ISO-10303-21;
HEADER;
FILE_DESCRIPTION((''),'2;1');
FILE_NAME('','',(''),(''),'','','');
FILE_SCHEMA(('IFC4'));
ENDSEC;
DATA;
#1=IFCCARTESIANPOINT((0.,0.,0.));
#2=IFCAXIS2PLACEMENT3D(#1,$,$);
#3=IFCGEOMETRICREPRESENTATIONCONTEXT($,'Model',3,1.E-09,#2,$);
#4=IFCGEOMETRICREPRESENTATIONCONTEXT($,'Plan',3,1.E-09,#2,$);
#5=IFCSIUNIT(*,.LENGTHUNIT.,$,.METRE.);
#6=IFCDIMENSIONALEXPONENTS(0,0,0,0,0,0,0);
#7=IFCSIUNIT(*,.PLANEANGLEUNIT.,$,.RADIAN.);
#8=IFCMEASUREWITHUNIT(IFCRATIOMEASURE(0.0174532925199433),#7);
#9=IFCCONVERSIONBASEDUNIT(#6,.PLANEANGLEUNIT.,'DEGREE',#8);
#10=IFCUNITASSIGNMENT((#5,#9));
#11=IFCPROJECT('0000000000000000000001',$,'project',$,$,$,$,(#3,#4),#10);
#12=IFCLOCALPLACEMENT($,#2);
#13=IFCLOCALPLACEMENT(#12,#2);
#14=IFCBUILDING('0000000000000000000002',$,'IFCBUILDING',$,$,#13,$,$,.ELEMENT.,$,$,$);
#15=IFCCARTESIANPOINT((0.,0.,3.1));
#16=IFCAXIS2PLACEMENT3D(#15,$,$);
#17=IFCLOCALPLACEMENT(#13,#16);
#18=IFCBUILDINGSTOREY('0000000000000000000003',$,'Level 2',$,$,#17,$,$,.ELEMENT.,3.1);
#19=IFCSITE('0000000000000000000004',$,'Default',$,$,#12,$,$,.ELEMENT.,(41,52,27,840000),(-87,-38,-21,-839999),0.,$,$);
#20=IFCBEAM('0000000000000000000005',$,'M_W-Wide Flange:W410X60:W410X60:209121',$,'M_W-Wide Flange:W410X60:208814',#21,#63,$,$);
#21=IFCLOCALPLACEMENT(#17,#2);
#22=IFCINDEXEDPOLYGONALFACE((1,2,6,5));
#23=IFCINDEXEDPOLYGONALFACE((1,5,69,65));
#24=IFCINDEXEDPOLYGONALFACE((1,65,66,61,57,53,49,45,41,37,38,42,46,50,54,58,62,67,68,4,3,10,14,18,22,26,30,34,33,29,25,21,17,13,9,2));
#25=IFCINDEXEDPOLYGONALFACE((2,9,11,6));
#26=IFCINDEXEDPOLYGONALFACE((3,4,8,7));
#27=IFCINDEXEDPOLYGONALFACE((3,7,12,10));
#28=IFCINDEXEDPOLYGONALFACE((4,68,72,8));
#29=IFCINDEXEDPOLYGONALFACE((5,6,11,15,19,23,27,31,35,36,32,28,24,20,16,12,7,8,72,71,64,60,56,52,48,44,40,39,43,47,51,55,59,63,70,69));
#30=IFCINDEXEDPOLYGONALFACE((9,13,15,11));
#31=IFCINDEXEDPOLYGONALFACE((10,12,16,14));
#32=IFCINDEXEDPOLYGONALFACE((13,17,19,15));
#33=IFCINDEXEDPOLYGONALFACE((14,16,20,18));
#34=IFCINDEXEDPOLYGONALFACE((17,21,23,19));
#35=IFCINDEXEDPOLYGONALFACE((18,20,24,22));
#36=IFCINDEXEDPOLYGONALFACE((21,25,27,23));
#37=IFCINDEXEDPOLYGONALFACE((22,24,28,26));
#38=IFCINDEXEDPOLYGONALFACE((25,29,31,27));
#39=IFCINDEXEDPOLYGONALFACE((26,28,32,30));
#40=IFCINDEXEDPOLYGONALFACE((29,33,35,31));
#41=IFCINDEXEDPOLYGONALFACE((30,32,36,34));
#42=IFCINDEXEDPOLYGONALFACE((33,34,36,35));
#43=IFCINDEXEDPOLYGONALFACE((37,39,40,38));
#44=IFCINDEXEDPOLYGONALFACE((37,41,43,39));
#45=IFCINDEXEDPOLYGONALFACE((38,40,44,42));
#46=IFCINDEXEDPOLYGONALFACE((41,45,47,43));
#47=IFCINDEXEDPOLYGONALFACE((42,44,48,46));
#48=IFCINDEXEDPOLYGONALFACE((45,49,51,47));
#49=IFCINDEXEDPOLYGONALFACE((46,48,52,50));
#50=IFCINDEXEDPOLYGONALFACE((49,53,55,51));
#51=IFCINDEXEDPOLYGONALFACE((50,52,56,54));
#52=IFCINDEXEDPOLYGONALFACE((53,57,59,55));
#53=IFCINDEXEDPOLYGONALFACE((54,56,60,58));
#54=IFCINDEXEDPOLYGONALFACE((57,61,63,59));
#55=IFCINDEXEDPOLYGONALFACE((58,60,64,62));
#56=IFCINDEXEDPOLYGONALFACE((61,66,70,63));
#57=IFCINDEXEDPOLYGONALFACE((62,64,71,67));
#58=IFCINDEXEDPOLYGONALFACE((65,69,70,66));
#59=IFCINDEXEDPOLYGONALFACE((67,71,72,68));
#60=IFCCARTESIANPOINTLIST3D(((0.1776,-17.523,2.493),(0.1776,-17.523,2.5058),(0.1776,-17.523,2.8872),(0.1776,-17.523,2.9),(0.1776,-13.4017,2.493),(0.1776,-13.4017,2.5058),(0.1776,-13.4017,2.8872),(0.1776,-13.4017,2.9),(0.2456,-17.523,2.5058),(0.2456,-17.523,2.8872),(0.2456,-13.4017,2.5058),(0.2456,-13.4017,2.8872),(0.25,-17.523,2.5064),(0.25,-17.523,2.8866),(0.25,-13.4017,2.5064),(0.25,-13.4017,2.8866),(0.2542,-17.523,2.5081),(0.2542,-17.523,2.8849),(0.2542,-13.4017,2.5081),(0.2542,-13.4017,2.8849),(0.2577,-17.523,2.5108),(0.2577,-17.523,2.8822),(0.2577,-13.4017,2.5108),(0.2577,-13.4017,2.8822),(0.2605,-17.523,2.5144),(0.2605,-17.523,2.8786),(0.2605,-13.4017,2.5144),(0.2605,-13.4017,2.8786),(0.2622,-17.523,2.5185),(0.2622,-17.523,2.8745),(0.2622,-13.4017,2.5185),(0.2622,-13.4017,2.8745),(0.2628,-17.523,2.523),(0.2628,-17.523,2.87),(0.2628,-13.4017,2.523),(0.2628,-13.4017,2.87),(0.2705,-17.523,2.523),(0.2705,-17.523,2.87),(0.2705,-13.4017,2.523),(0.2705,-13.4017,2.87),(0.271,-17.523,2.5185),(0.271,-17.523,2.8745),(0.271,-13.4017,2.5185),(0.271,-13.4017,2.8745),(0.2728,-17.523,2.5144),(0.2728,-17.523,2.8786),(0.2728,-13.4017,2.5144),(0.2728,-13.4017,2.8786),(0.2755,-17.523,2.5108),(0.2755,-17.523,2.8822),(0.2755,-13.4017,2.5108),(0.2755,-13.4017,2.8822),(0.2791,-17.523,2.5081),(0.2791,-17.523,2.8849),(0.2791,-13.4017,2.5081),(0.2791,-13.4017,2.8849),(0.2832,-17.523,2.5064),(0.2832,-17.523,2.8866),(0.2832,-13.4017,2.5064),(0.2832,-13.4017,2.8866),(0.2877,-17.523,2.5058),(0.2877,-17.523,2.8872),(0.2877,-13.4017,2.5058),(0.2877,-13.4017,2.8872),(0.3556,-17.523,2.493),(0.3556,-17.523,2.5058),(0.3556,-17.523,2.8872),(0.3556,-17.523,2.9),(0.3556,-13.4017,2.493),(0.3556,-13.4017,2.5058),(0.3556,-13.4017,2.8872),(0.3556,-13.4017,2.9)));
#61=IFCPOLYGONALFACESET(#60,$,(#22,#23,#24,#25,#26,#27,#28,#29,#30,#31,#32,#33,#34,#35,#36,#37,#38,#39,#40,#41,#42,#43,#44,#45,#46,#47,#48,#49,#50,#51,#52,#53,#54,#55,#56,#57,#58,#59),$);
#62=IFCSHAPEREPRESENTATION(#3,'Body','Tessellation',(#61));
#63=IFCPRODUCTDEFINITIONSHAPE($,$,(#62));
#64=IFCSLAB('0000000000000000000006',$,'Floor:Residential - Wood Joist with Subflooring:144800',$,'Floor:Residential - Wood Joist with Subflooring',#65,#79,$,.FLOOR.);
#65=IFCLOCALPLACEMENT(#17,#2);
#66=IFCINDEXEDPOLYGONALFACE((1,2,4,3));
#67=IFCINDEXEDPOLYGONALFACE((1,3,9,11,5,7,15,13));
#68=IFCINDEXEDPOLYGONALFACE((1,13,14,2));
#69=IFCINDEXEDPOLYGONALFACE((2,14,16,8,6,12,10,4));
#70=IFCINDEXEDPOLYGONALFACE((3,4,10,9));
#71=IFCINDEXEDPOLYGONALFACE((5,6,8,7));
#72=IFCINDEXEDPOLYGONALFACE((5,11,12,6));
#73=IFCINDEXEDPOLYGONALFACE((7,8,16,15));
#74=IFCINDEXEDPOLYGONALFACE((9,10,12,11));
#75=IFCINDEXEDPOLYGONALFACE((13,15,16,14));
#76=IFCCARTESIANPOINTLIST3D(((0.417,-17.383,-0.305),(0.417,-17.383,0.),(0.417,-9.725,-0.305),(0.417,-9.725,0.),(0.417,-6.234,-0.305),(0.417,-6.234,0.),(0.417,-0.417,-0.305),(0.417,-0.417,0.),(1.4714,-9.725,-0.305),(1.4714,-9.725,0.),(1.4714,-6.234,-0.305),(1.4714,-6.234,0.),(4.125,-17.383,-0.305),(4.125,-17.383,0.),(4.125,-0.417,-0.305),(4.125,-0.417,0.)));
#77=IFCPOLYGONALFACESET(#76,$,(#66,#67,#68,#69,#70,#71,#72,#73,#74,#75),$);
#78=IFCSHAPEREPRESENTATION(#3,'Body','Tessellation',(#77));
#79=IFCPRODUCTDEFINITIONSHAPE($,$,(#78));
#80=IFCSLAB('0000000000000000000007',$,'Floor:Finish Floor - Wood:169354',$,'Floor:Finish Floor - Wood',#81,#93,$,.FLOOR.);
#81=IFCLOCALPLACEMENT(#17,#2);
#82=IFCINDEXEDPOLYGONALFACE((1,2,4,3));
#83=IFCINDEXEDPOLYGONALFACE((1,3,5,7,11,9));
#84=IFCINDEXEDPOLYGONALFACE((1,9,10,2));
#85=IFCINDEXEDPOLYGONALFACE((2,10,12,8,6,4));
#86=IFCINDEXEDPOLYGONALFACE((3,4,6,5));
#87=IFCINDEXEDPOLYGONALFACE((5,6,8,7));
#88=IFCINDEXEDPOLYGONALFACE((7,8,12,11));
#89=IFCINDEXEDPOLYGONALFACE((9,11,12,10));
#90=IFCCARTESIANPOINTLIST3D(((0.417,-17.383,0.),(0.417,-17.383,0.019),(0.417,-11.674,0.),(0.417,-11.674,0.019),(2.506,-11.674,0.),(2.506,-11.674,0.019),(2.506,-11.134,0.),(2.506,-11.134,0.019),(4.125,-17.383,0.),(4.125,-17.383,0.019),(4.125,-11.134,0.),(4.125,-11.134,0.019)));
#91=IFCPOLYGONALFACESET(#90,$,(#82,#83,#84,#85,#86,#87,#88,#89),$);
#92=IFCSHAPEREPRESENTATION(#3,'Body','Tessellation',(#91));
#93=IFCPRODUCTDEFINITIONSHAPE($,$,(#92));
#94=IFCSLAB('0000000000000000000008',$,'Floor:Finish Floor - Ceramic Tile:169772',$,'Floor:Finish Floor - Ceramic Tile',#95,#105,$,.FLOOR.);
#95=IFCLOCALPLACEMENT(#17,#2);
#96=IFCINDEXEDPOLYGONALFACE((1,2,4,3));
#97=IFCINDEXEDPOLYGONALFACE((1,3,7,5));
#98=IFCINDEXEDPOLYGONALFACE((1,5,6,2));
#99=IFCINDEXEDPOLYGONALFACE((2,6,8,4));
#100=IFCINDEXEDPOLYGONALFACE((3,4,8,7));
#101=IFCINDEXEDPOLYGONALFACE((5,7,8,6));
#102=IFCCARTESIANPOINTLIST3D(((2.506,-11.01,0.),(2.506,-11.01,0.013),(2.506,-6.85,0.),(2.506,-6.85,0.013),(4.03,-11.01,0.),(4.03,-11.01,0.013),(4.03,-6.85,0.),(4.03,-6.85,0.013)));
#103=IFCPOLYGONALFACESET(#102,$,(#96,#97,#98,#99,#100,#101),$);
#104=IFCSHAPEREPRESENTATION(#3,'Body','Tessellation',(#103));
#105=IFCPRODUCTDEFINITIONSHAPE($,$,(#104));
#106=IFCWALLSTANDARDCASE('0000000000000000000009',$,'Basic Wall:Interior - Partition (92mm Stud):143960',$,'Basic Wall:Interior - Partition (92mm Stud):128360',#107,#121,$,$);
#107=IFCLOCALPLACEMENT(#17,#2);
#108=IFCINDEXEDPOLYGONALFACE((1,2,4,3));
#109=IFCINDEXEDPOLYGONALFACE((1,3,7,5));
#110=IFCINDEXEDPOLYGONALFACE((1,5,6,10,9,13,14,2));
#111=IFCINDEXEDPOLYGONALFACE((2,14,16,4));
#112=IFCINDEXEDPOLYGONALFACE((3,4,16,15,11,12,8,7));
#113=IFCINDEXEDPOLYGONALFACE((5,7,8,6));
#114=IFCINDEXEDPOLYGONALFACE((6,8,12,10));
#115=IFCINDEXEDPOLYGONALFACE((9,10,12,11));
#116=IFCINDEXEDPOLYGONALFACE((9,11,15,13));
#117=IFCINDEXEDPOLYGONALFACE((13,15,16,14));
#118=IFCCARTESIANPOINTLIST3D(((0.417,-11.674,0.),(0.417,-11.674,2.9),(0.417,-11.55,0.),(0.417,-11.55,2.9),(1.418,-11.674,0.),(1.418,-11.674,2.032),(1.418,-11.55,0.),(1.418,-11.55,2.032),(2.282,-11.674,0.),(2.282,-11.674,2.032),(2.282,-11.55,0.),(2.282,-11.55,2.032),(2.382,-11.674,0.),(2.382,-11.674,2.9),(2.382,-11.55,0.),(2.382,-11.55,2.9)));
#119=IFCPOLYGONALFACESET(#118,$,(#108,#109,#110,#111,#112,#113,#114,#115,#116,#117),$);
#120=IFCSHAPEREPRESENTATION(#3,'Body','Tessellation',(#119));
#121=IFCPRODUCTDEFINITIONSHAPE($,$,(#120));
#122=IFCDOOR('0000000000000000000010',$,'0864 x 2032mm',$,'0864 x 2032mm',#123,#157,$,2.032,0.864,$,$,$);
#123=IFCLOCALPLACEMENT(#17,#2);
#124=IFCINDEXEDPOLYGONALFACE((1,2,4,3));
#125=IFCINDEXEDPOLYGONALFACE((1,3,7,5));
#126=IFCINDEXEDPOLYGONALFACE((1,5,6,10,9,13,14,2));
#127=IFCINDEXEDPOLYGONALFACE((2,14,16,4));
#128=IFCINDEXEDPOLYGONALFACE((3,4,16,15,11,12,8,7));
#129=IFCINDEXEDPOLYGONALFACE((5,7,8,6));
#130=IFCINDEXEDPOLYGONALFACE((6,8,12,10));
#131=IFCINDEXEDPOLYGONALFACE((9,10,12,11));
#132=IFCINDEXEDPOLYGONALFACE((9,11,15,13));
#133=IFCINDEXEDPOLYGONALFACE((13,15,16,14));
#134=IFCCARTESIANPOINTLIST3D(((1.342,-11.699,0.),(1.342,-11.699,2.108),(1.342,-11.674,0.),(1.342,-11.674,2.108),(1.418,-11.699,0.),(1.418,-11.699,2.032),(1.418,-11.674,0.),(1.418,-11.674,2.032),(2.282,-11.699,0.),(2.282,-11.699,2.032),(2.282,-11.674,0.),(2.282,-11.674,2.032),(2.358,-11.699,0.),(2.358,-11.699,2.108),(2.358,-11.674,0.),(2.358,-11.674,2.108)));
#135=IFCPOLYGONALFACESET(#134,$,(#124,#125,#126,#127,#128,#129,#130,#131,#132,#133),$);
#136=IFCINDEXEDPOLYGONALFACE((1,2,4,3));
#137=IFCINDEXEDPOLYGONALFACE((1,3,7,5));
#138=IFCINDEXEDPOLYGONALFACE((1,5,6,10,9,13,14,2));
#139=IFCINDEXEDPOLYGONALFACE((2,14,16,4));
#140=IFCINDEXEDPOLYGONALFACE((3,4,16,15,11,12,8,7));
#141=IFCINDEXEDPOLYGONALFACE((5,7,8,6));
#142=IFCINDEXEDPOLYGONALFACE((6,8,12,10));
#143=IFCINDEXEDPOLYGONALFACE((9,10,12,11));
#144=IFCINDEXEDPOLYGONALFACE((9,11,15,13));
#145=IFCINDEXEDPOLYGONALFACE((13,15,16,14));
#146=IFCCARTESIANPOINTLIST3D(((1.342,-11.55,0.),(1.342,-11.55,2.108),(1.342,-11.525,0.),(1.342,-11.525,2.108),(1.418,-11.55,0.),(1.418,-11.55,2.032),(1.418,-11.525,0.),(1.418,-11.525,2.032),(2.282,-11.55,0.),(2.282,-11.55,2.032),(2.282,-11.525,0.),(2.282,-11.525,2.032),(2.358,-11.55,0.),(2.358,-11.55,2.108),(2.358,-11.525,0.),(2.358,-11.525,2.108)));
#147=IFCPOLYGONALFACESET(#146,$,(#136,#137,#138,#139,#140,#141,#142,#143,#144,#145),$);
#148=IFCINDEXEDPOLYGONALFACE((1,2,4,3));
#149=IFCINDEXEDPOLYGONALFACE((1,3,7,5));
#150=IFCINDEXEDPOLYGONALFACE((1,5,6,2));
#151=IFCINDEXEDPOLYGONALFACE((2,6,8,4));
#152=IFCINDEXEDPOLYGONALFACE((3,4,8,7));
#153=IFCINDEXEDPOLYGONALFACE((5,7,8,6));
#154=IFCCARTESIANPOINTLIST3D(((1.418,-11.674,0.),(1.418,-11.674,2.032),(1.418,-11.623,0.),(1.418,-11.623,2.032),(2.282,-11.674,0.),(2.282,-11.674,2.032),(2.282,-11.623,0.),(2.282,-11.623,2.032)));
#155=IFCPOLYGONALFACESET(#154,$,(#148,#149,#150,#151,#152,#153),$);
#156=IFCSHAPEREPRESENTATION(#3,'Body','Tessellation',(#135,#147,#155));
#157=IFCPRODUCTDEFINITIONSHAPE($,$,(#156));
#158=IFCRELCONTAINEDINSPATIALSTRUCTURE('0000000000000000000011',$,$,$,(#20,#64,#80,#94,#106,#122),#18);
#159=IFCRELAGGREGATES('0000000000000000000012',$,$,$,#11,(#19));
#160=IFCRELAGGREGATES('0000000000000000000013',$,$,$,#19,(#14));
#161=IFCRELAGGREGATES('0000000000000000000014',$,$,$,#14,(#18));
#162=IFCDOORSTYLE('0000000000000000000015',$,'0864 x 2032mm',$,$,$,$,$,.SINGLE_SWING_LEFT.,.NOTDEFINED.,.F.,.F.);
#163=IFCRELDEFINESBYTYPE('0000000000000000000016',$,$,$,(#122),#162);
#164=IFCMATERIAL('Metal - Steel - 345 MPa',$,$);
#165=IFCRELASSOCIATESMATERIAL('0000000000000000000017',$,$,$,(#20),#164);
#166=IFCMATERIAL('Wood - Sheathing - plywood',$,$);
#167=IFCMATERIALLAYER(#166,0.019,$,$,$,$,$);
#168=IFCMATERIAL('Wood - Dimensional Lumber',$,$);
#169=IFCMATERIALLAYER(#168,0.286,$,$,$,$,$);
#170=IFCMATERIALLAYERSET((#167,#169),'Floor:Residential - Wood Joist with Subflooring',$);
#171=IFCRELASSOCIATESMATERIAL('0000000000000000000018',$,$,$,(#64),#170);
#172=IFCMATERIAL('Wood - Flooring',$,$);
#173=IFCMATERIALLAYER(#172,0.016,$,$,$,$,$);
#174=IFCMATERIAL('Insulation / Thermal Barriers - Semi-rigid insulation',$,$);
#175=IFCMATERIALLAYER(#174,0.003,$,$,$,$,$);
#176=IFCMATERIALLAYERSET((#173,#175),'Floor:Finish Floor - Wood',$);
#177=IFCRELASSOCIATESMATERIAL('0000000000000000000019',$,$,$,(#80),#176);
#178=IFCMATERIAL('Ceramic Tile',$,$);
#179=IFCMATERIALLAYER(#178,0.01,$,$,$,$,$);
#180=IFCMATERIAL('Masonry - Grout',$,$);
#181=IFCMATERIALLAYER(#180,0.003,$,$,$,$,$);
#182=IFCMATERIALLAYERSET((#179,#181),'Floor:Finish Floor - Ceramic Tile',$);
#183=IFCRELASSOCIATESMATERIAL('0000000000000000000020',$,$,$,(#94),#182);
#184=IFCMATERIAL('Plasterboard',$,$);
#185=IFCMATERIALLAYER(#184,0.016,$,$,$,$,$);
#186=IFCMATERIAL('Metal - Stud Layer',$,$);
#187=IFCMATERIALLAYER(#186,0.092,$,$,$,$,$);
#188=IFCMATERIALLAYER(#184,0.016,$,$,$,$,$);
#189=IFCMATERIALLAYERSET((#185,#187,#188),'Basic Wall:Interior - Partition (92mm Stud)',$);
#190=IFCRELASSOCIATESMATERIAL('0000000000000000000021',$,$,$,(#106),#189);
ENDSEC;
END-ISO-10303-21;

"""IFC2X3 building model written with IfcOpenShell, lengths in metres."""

from ifc_helpers import new_model, entity, si_unit, converted_unit, frame, frame_2d, origin, origin_2d_with_axis, place, context, project, spatial, polyline, circle_curve, parameter, trimmed, segment, composite_curve, rectangle, outline, extrude, source, transform, mapped, material, layer, layer_set, layer_usage, type_object, type_shapes, element, fill, save


model = new_model("IFC2X3")

# Units and contexts
model_context = context("Model", 3, precision=1e-09, world=origin())
plan_context = context("Plan", 3, precision=1e-09, world=origin())
ifc_project = project(units=[si_unit("LENGTHUNIT", "METRE"), converted_unit("PLANEANGLEUNIT", "DEGREE", entity("IfcRatioMeasure", 0.0174532925199433), si_unit("PLANEANGLEUNIT", "RADIAN"), dimensions=[0, 0, 0, 0, 0, 0, 0])], contexts=[model_context, plan_context])

# Site, building, storey
site_placement = place(None, origin())
site = spatial("IfcSite", under=ifc_project, at=site_placement, Name="Default", CompositionType="ELEMENT", RefLatitude=(41, 52, 27, 840000), RefLongitude=(-87, -38, -21, -839999), RefElevation=0.0)
building_placement = place(site_placement, origin())
building = spatial("IfcBuilding", under=site, at=building_placement, Name="IFCBUILDING", CompositionType="ELEMENT")
storey_placement = place(building_placement, frame((0.0, 0.0, 3.1)))
storey = spatial("IfcBuildingStorey", under=building, at=storey_placement, Name="Level 2", CompositionType="ELEMENT", Elevation=3.1)

# Beam
ifc_material_1 = material(Name="Metal - Steel - 345 MPa")
beam_placement = place(storey_placement, frame((0.2666, -13.4017, 2.9), z_axis=(0.0, 0.0, 1.0), x_axis=(-1.0, 0.0, 0.0)))
element("IfcBeam", 1, at=beam_placement, inside=storey, material=ifc_material_1, Name="M_W-Wide Flange:W410X60:W410X60:209121", ObjectType="M_W-Wide Flange:W410X60:208814", context=model_context, shape_type="SweptSolid", body=[
    extrude(outline(composite_curve([segment(polyline([(0.1907, -0.089), (0.2035, -0.089)]), True, "CONTINUOUS"), segment(polyline([(0.2035, -0.089), (0.2035, 0.089)]), True, "CONTINUOUS"), segment(polyline([(0.2035, 0.089), (0.1907, 0.089)]), True, "CONTINUOUS"), segment(polyline([(0.1907, 0.089), (0.1907, 0.021)]), True, "CONTINUOUS"), segment(trimmed(circle_curve(frame_2d((0.1735, 0.021), x_axis=(1.0, 0.0)), 0.0172), [parameter(270.0)], [parameter(360.0)], True, "PARAMETER"), False, "CONTINUOUS"), segment(polyline([(0.1735, 0.0038), (-0.1735, 0.0038)]), True, "CONTINUOUS"), segment(trimmed(circle_curve(frame_2d((-0.1735, 0.021), x_axis=(0.0, -1.0)), 0.0172), [parameter(270.0)], [parameter(360.0)], True, "PARAMETER"), False, "CONTINUOUS"), segment(polyline([(-0.1907, 0.021), (-0.1907, 0.089)]), True, "CONTINUOUS"), segment(polyline([(-0.1907, 0.089), (-0.2035, 0.089)]), True, "CONTINUOUS"), segment(polyline([(-0.2035, 0.089), (-0.2035, -0.089)]), True, "CONTINUOUS"), segment(polyline([(-0.2035, -0.089), (-0.1907, -0.089)]), True, "CONTINUOUS"), segment(polyline([(-0.1907, -0.089), (-0.1907, -0.0211)]), True, "CONTINUOUS"), segment(trimmed(circle_curve(frame_2d((-0.1735, -0.0211), x_axis=(-1.0, 0.0)), 0.0172), [parameter(270.0)], [parameter(0.0)], True, "PARAMETER"), False, "CONTINUOUS"), segment(polyline([(-0.1735, -0.0039), (0.1735, -0.0039)]), True, "CONTINUOUS"), segment(trimmed(circle_curve(frame_2d((0.1735, -0.0211), x_axis=(0.0, 1.0)), 0.0172), [parameter(270.0)], [parameter(0.0)], True, "PARAMETER"), False, "CONTINUOUS"), segment(polyline([(0.1907, -0.0211), (0.1907, -0.089)]), True, "CONTINUOUS")], self_intersect=False)), frame((0.0, 4.1213, -0.2035), z_axis=(0.0, -1.0, 0.0), x_axis=(0.0, 0.0, -1.0)), (0.0, 0.0, 1.0), 4.1213),
])

# Slabs
ifc_material_2 = material(Name="Wood - Sheathing - plywood")
ifc_layer_1 = layer(ifc_material_2, 0.019)
ifc_material_3 = material(Name="Wood - Dimensional Lumber")
ifc_layer_2 = layer(ifc_material_3, 0.286)
ifc_layer_set_1 = layer_set([ifc_layer_1, ifc_layer_2], Name="Floor:Residential - Wood Joist with Subflooring")
ifc_layer_usage_1 = layer_usage(ifc_layer_set_1, "AXIS3", "POSITIVE", 0.0)
slab_1_placement = place(storey_placement, frame((0.417, -17.383, -0.305)))
element("IfcSlab", 2, at=slab_1_placement, inside=storey, material=ifc_layer_usage_1, Name="Floor:Residential - Wood Joist with Subflooring:144800", ObjectType="Floor:Residential - Wood Joist with Subflooring", PredefinedType="FLOOR", context=model_context, shape_type="SweptSolid", body=[
    extrude(outline(polyline([(-1.854, 8.483), (-1.854, -8.483), (1.854, -8.483), (1.854, -0.825), (0.7996, -0.825), (0.7996, 2.666), (1.854, 2.666), (1.854, 8.483), (-1.854, 8.483)])), frame((1.854, 8.483, 0.305), z_axis=(0.0, 0.0, -1.0), x_axis=(-1.0, 0.0, 0.0)), (0.0, 0.0, 1.0), 0.305),
])
ifc_material_4 = material(Name="Wood - Flooring")
ifc_layer_3 = layer(ifc_material_4, 0.016)
ifc_material_5 = material(Name="Insulation / Thermal Barriers - Semi-rigid insulation")
ifc_layer_4 = layer(ifc_material_5, 0.003)
ifc_layer_set_2 = layer_set([ifc_layer_3, ifc_layer_4], Name="Floor:Finish Floor - Wood")
ifc_layer_usage_2 = layer_usage(ifc_layer_set_2, "AXIS3", "POSITIVE", 0.0)
slab_2_placement = place(storey_placement, frame((0.417, -17.383, 0.0)))
element("IfcSlab", 3, at=slab_2_placement, inside=storey, material=ifc_layer_usage_2, Name="Floor:Finish Floor - Wood:169354", ObjectType="Floor:Finish Floor - Wood", PredefinedType="FLOOR", context=model_context, shape_type="SweptSolid", body=[
    extrude(outline(polyline([(-1.854, -3.1245), (1.854, -3.1245), (1.854, 2.5845), (-0.235, 2.5845), (-0.235, 3.1245), (-1.854, 3.1245), (-1.854, -3.1245)])), frame((1.854, 3.1245, 0.019), z_axis=(0.0, 0.0, -1.0), x_axis=(-1.0, 0.0, 0.0)), (0.0, 0.0, 1.0), 0.019),
])
ifc_material_6 = material(Name="Ceramic Tile")
ifc_layer_5 = layer(ifc_material_6, 0.01)
ifc_material_7 = material(Name="Masonry - Grout")
ifc_layer_6 = layer(ifc_material_7, 0.003)
ifc_layer_set_3 = layer_set([ifc_layer_5, ifc_layer_6], Name="Floor:Finish Floor - Ceramic Tile")
ifc_layer_usage_3 = layer_usage(ifc_layer_set_3, "AXIS3", "POSITIVE", 0.0)
slab_3_placement = place(storey_placement, frame((2.506, -11.01, 0.0)))
element("IfcSlab", 4, at=slab_3_placement, inside=storey, material=ifc_layer_usage_3, Name="Floor:Finish Floor - Ceramic Tile:169772", ObjectType="Floor:Finish Floor - Ceramic Tile", PredefinedType="FLOOR", context=model_context, shape_type="SweptSolid", body=[
    extrude(rectangle(XDim=4.16, YDim=1.524, at=frame_2d((0.0, 0.0), x_axis=(0.0, -1.0))), frame((0.762, 2.08, 0.013), z_axis=(0.0, 0.0, -1.0), x_axis=(-1.0, 0.0, 0.0)), (0.0, 0.0, 1.0), 0.013),
])

# Shared definitions
ifc_material_8 = material(Name="Metal - Stud Layer")
ifc_material_9 = material(Name="Plasterboard")

# Wall, opening, door
ifc_layer_7 = layer(ifc_material_9, 0.016)
ifc_layer_8 = layer(ifc_material_8, 0.092)
ifc_layer_9 = layer(ifc_material_9, 0.016)
ifc_layer_set_4 = layer_set([ifc_layer_7, ifc_layer_8, ifc_layer_9], Name="Basic Wall:Interior - Partition (92mm Stud)")
ifc_layer_usage_4 = layer_usage(ifc_layer_set_4, "AXIS2", "NEGATIVE", 0.062)
wall_1_placement = place(storey_placement, frame((2.382, -11.612, 0.0), z_axis=(0.0, 0.0, 1.0), x_axis=(-1.0, 0.0, 0.0)))
wall_1 = element("IfcWallStandardCase", 5, at=wall_1_placement, inside=storey, material=ifc_layer_usage_4, Name="Basic Wall:Interior - Partition (92mm Stud):143960", ObjectType="Basic Wall:Interior - Partition (92mm Stud):128360", context=model_context, shape_type="SweptSolid", body=[
    extrude(rectangle(XDim=1.965, YDim=0.124, at=frame_2d((0.9825, 0.0), x_axis=(-1.0, 0.0))), origin(), (0.0, 0.0, 1.0), 2.9),
])
opening_1_placement = place(wall_1_placement, frame((0.1, -0.062, 0.0)))
opening_1 = element("IfcOpeningElement", 6, at=opening_1_placement, cuts=wall_1, ObjectType="Opening", context=model_context, shape_type="SweptSolid", body=[
    extrude(rectangle(XDim=0.864, YDim=2.032, at=frame_2d((1.016, 0.432), x_axis=(0.0, -1.0))), frame((0.0, 0.0, 0.0), z_axis=(0.0, 1.0, 0.0), x_axis=(0.0, 0.0, 1.0)), (0.0, 0.0, 1.0), 0.124),
])
door_style = type_object("IfcDoorStyle", Name="0864 x 2032mm", ConstructionType="NOTDEFINED", OperationType="SINGLE_SWING_LEFT", ParameterTakesPrecedence=False, Sizeable=False)
shared_shape_1 = source(origin(), model_context, "Body", "SweptSolid", [
    extrude(outline(polyline([(-0.508, -1.073), (0.508, -1.073), (0.508, 1.035), (0.432, 1.035), (0.432, -0.997), (-0.432, -0.997), (-0.432, 1.035), (-0.508, 1.035), (-0.508, -1.073)])), frame((0.432, 0.149, 1.035), z_axis=(0.0, -1.0, 0.0), x_axis=(-1.0, 0.0, 0.0)), (0.0, 0.0, 1.0), 0.025),
    extrude(outline(polyline([(-1.073, -0.508), (1.035, -0.508), (1.035, -0.432), (-0.997, -0.432), (-0.997, 0.432), (1.035, 0.432), (1.035, 0.508), (-1.073, 0.508), (-1.073, -0.508)])), frame((0.432, 0.0, 1.035), z_axis=(0.0, -1.0, 0.0), x_axis=(0.0, 0.0, -1.0)), (0.0, 0.0, 1.0), 0.025),
    extrude(rectangle(XDim=0.864, YDim=0.051, at=origin_2d_with_axis()), frame((0.432, 0.0985, 0.0)), (0.0, 0.0, 1.0), 2.032),
])
type_shapes(door_style, [shared_shape_1])
door_placement = place(opening_1_placement, origin())
door = element("IfcDoor", 7, at=door_placement, inside=storey, type_object=door_style, Name="0864 x 2032mm", ObjectType="0864 x 2032mm", OverallHeight=2.032, OverallWidth=0.864, context=model_context, shape_type="MappedRepresentation", body=[
    mapped(shared_shape_1, transform((0.0, 0.0, 0.0), scale=1.0)),
])
fill(opening_1, door)

save(model, "model.ifc")
